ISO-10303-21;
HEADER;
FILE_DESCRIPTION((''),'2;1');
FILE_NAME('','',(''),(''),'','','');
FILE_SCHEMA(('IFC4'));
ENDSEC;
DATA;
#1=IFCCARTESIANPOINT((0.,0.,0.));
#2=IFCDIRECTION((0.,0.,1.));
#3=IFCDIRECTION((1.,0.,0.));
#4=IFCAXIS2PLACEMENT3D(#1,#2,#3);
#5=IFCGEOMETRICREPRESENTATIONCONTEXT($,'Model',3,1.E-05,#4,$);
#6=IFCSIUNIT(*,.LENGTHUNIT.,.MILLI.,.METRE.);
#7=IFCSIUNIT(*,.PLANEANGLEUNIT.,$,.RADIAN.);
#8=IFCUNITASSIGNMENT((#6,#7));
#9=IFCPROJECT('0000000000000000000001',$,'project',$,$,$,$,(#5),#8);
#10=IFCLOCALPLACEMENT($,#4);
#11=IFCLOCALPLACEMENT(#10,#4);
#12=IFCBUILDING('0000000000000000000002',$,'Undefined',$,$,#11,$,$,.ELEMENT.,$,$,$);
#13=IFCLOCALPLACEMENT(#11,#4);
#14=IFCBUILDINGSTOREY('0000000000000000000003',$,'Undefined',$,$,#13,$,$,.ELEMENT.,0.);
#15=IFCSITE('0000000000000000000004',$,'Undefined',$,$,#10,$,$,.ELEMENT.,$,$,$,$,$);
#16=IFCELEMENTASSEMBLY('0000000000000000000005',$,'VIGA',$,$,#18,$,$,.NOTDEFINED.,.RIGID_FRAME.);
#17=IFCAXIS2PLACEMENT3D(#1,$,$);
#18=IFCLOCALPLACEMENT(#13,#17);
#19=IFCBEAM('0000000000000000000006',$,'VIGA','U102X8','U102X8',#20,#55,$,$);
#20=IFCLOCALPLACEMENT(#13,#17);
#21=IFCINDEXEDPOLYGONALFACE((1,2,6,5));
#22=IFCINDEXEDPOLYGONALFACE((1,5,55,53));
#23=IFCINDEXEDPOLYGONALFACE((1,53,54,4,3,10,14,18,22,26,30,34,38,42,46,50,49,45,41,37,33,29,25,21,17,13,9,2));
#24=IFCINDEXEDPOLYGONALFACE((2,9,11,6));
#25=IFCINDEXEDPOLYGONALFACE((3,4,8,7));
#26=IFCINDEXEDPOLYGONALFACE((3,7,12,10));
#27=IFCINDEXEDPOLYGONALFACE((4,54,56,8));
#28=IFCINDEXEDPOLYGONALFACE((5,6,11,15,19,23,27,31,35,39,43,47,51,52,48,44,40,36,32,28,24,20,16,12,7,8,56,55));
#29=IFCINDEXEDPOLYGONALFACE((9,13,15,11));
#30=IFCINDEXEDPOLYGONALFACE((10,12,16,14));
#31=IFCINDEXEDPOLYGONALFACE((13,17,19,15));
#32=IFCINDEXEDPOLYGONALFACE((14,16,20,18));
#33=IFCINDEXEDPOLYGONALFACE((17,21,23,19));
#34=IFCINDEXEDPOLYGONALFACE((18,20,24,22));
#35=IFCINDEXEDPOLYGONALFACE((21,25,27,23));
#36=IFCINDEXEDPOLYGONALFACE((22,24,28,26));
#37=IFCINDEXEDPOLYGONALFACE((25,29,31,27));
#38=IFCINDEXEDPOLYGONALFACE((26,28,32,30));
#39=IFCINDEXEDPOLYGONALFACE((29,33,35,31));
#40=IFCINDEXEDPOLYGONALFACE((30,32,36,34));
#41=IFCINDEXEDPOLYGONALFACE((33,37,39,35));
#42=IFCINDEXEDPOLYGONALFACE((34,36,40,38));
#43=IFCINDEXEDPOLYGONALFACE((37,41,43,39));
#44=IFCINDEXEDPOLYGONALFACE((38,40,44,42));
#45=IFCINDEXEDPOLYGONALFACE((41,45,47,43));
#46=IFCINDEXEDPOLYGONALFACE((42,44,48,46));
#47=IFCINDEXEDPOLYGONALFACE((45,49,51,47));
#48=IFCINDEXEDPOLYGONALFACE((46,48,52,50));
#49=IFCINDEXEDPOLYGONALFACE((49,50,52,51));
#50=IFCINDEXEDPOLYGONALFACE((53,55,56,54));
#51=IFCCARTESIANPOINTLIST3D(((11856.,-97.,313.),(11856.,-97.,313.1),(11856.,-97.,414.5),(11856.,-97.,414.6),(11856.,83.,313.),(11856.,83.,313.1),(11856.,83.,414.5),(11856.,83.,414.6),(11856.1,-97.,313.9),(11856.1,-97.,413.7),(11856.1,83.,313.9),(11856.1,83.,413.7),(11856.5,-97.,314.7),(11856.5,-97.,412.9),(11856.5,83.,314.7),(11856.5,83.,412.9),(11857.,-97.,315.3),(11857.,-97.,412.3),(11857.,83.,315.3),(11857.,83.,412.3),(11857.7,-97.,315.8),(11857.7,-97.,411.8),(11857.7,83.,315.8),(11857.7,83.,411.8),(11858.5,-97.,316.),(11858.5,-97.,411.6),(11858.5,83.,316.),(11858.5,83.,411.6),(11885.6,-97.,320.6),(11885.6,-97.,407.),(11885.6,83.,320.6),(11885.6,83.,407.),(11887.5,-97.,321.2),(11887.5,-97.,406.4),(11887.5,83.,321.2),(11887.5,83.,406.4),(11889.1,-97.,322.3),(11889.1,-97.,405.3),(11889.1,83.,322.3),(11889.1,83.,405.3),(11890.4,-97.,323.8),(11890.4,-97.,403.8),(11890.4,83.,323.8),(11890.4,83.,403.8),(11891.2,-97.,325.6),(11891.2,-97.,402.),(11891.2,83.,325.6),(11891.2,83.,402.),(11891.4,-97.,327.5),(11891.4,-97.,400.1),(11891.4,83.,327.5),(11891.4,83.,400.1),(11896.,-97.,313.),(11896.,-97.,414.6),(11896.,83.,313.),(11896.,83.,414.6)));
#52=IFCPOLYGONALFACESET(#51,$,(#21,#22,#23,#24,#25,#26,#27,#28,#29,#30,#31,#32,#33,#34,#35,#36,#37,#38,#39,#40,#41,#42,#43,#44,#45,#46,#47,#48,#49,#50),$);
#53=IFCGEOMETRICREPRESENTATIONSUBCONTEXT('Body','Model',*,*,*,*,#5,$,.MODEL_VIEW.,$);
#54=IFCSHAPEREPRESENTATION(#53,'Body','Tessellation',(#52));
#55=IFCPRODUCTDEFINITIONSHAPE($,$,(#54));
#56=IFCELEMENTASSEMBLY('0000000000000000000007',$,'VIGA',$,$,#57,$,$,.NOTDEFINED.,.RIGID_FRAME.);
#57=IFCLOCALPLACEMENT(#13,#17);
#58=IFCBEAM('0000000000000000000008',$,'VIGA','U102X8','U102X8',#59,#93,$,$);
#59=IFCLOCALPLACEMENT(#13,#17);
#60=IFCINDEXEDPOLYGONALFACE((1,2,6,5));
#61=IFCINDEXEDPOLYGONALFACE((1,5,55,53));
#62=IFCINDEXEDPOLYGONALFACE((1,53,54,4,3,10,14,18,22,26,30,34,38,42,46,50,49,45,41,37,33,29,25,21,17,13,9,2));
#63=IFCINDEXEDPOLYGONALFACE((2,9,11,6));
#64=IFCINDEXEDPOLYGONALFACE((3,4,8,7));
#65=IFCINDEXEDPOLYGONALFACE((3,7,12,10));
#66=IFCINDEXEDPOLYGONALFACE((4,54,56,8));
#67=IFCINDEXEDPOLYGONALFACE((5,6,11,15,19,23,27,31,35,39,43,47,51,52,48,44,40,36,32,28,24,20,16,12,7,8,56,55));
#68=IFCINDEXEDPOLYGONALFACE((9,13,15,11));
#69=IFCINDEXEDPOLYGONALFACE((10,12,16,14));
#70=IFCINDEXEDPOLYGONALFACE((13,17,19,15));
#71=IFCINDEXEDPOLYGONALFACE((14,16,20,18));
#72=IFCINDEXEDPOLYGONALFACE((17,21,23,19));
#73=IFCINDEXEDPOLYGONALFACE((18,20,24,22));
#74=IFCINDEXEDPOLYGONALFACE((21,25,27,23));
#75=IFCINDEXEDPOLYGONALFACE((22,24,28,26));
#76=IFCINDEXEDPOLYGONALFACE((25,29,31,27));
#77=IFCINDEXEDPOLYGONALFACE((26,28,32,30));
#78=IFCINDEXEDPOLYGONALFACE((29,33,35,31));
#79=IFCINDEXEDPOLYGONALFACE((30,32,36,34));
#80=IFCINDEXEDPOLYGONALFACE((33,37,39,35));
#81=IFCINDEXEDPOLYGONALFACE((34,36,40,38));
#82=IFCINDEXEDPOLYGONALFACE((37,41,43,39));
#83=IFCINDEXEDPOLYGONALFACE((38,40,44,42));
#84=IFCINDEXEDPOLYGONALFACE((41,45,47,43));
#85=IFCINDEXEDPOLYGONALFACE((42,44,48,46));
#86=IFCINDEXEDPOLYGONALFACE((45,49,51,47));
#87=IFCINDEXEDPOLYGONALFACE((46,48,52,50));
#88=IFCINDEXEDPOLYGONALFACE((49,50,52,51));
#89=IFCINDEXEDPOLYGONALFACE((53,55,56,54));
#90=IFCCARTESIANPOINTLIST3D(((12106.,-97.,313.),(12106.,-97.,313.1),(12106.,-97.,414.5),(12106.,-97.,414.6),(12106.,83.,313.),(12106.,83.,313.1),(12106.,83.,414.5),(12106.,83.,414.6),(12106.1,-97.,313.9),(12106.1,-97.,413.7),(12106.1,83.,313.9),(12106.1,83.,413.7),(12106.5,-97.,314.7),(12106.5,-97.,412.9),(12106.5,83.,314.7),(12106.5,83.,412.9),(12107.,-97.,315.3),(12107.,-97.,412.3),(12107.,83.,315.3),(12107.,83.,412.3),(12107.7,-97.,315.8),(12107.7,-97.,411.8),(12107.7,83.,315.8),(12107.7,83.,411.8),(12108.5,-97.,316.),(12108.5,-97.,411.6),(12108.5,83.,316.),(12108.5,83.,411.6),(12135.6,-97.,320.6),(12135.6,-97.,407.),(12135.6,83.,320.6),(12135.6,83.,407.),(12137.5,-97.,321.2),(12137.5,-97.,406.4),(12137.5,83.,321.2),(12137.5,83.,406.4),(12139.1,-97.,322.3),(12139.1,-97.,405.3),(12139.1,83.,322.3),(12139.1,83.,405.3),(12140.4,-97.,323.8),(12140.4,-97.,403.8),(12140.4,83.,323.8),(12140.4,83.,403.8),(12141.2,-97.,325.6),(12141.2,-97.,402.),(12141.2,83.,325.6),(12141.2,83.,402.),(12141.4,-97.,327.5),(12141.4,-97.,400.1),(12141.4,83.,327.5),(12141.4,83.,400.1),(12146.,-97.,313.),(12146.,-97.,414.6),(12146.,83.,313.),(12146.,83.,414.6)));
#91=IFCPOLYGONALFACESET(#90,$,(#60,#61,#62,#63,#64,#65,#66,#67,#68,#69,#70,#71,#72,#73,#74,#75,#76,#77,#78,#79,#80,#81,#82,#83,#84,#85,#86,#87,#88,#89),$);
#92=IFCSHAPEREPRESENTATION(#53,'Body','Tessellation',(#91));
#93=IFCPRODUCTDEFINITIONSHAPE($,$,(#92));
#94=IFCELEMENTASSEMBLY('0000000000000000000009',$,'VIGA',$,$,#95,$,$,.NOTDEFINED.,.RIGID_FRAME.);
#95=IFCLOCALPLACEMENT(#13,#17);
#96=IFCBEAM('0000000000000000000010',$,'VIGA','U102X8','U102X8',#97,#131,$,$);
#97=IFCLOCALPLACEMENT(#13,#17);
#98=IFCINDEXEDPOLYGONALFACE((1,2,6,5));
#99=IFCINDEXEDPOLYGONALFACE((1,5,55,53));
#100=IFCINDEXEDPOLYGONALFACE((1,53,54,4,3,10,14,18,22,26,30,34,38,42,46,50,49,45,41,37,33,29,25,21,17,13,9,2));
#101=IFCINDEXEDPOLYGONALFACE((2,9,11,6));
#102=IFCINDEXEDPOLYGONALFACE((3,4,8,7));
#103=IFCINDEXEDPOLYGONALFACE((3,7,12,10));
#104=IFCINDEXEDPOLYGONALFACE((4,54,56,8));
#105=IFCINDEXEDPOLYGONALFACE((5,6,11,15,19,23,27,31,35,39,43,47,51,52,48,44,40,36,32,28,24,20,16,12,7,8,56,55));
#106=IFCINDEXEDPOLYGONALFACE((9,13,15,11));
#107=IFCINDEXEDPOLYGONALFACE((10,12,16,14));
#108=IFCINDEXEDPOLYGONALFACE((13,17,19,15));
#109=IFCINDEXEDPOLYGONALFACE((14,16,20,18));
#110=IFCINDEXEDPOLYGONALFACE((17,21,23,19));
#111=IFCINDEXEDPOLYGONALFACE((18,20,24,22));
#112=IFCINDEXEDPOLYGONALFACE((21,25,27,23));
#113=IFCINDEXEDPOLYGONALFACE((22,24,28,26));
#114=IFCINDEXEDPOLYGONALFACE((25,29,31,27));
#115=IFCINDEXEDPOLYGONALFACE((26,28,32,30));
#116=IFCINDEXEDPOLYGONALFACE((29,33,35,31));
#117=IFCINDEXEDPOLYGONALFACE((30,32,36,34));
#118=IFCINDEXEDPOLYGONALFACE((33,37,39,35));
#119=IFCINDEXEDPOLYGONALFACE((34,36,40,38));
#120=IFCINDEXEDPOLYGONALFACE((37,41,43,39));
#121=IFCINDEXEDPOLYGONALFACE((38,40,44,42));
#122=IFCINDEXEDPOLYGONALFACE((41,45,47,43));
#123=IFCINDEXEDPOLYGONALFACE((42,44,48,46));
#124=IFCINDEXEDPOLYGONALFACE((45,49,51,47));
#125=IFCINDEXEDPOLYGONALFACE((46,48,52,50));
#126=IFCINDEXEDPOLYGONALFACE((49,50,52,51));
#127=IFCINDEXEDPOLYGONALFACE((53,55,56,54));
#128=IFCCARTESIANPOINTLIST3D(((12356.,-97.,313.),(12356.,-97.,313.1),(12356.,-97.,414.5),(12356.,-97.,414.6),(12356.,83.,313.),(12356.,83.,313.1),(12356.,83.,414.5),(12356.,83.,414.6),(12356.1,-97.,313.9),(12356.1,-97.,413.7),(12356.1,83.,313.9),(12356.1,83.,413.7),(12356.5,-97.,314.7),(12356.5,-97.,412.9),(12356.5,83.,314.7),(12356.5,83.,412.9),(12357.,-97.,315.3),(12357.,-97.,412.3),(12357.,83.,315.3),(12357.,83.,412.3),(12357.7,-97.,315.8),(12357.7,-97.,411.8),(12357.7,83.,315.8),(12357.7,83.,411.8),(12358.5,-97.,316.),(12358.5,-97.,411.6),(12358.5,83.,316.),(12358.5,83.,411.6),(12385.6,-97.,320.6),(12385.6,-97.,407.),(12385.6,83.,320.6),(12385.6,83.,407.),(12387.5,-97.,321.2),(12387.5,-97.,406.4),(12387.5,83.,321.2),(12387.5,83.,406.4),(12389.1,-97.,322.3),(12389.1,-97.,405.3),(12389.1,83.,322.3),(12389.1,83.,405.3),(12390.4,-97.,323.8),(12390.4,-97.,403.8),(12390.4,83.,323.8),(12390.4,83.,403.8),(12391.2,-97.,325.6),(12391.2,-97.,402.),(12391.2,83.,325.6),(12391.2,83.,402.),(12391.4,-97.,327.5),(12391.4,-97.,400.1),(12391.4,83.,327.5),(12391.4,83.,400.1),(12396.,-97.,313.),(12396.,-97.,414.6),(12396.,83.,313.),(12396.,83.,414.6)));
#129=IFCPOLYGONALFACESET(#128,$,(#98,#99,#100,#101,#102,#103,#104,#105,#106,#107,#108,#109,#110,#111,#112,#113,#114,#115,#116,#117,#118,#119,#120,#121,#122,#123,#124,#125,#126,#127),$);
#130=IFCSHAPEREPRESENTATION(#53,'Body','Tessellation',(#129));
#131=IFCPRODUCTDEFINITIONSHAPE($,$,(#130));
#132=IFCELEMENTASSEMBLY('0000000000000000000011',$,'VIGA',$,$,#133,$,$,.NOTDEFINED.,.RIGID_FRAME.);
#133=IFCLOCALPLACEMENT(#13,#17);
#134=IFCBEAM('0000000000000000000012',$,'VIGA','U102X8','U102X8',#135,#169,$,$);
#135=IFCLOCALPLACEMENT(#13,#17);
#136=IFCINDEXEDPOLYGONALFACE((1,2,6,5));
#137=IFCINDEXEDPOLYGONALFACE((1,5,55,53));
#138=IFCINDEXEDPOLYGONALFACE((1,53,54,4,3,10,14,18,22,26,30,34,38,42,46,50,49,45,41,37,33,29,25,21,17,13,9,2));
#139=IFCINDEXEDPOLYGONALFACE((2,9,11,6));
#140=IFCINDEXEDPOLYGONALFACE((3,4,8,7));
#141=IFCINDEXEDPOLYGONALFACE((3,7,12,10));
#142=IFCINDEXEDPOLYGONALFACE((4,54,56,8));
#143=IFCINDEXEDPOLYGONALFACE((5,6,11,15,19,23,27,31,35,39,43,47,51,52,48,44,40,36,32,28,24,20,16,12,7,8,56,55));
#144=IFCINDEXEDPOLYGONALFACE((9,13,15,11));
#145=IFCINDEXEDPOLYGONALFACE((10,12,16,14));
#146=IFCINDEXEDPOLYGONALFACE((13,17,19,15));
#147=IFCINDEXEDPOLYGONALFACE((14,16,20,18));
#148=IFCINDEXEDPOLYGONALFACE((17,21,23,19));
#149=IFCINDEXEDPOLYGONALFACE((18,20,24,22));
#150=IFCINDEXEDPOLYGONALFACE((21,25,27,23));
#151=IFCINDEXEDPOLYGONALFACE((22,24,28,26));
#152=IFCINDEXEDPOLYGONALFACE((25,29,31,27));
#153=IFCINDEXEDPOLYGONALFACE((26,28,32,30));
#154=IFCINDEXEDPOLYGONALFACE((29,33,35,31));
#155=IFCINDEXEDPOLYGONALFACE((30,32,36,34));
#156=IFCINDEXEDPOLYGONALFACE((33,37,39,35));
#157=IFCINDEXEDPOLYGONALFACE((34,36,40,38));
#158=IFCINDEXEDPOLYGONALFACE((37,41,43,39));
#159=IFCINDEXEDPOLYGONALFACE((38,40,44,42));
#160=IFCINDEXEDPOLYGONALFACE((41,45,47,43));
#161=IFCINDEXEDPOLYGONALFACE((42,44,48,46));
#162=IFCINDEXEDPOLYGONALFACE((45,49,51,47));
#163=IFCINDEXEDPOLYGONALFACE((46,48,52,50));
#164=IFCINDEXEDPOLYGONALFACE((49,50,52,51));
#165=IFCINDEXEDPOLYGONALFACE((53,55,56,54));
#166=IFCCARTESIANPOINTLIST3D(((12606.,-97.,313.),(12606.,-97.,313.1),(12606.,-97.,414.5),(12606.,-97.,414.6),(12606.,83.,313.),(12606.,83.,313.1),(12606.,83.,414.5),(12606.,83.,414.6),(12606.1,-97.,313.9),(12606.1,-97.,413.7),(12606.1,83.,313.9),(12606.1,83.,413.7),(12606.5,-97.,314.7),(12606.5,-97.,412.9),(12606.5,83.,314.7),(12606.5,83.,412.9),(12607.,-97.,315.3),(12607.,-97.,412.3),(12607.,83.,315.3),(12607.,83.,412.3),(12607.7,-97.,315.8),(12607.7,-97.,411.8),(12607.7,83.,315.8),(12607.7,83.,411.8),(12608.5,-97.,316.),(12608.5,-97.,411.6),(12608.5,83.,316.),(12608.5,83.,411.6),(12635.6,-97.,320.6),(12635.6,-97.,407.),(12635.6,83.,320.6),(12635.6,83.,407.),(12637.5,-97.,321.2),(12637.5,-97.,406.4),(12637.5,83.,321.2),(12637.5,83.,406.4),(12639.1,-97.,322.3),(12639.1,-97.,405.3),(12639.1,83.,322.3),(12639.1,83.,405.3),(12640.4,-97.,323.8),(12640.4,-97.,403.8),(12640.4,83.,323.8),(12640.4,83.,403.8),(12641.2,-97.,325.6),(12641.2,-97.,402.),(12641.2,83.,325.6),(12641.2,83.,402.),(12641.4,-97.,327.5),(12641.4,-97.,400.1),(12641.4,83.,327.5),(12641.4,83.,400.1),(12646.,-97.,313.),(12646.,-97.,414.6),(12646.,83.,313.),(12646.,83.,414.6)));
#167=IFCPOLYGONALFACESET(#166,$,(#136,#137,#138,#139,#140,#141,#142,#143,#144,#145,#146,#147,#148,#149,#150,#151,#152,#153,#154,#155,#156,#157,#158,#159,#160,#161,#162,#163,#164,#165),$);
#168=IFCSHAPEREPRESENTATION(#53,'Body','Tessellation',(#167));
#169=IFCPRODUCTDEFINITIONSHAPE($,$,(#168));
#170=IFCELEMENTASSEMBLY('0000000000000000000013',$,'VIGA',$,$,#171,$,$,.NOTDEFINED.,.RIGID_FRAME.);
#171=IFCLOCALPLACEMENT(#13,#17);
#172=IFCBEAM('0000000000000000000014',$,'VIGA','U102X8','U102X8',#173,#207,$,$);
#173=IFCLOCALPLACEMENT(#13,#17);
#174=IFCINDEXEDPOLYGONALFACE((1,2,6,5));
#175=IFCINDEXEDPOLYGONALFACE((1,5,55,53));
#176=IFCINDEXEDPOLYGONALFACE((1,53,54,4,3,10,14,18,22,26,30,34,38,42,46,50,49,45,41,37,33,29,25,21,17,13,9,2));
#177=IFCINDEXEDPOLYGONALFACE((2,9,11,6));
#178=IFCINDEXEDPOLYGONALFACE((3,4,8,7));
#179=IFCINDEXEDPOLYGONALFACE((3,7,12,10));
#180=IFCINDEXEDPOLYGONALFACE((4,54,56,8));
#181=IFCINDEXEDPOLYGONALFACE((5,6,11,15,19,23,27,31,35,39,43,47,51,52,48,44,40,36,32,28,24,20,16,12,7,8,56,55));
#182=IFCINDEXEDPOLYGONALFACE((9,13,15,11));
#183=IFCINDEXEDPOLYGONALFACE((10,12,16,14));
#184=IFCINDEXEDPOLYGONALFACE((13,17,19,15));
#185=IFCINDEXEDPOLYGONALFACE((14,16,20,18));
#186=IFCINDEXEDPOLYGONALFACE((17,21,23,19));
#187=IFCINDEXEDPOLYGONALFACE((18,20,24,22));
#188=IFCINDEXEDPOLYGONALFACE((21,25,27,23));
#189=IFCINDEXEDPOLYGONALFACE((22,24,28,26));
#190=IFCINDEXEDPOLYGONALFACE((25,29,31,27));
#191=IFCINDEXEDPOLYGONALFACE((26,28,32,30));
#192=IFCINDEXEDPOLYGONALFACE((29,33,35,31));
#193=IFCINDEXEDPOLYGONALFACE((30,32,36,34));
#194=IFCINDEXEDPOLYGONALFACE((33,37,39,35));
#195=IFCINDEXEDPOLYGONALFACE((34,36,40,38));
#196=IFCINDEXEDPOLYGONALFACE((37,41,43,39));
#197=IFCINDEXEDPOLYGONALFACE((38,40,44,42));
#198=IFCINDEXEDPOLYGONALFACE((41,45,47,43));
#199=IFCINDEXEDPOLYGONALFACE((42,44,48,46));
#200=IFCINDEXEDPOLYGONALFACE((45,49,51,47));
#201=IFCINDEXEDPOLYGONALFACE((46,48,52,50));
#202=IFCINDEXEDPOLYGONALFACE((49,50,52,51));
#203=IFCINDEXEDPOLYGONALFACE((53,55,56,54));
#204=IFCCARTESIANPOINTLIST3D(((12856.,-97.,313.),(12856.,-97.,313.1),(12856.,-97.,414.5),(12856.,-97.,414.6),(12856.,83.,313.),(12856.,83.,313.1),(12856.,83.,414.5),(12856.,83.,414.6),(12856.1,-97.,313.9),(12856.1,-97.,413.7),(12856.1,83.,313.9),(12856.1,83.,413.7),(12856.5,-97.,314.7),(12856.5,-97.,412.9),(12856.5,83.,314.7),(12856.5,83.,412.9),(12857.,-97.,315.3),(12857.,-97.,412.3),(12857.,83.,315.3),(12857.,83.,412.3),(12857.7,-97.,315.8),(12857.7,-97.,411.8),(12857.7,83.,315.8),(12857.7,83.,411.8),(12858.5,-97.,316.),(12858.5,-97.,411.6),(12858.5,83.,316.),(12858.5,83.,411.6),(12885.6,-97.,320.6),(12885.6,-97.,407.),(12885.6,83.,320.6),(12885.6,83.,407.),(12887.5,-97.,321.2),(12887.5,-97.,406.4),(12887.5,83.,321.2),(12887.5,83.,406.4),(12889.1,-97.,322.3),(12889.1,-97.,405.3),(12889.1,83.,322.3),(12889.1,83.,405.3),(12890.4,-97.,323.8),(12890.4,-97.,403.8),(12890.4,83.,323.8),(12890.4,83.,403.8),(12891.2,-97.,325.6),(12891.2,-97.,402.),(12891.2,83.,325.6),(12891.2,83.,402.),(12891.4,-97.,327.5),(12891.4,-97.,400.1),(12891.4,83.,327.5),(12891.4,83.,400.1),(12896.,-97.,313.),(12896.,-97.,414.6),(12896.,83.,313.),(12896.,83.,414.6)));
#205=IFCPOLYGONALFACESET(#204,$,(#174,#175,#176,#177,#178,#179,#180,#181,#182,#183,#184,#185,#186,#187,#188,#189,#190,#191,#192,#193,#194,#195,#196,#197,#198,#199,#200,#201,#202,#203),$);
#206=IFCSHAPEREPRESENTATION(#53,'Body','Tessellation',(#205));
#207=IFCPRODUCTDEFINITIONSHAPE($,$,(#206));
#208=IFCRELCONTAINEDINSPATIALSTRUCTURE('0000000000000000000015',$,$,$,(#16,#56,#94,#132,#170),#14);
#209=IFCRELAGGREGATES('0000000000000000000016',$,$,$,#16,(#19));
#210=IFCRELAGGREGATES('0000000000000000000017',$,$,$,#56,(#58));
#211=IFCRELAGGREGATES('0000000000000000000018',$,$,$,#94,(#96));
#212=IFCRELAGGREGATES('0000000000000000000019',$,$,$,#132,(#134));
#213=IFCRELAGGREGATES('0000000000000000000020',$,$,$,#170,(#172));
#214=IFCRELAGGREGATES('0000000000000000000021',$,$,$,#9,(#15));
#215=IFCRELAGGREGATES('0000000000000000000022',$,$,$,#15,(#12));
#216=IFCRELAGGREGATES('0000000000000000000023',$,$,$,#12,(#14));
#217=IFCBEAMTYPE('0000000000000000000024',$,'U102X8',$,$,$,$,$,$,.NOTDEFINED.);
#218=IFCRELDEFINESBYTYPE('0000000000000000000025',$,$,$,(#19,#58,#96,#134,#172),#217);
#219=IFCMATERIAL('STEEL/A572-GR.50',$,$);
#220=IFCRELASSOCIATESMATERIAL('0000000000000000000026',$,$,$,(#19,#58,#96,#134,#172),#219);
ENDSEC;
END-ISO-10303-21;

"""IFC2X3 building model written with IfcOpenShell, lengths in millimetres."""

from ifc_helpers import new_model, si_unit, frame, origin_with_axes, origin_2d_with_axis, place, context, subcontext, project, spatial, u_section, extrude, material, type_object, element, aggregate, save


model = new_model("IFC2X3")

# Units and contexts
model_context = context("Model", 3, precision=1e-05, world=origin_with_axes())
body_context = subcontext(model_context, "Body", "Model", "MODEL_VIEW")
ifc_project = project(units=[si_unit("LENGTHUNIT", "METRE", prefix="MILLI"), si_unit("PLANEANGLEUNIT", "RADIAN")], contexts=[model_context])

# Site, building, storey
site_placement = place(None, origin_with_axes())
site = spatial("IfcSite", under=ifc_project, at=site_placement, Name="Undefined", CompositionType="ELEMENT")
building_placement = place(site_placement, origin_with_axes())
building = spatial("IfcBuilding", under=site, at=building_placement, Name="Undefined", CompositionType="ELEMENT")
storey_placement = place(building_placement, origin_with_axes())
storey = spatial("IfcBuildingStorey", under=building, at=storey_placement, Name="Undefined", CompositionType="ELEMENT", Elevation=0.0)

# Element assemblies, beams
ifc_material = material(Name="STEEL/A572-GR.50")
beam_type = type_object("IfcBeamType", Name="U102X8", PredefinedType="NOTDEFINED")
assembly_1_placement = place(storey_placement, origin_with_axes())
assembly_1 = element("IfcElementAssembly", 1, at=assembly_1_placement, inside=storey, Name="VIGA", AssemblyPlace="NOTDEFINED", PredefinedType="RIGID_FRAME")
beam_1_placement = place(assembly_1_placement, frame((11876.0, 83.0, 363.8), z_axis=(0.0, 0.0, 1.0), x_axis=(0.0, -1.0, 0.0)))
beam_1 = element("IfcBeam", 2, at=beam_1_placement, type_object=beam_type, material=ifc_material, Name="VIGA", Description="U102X8", ObjectType="U102X8", context=body_context, shape_type="SweptSolid", body=[
    extrude(u_section(Depth=101.6, FlangeWidth=40.0, WebThickness=4.6, FlangeThickness=6.0, FilletRadius=7.0, EdgeRadius=3.0, FlangeSlope=0.16839, at=origin_2d_with_axis()), frame((180.0, 0.0, 0.0), z_axis=(-1.0, 0.0, 0.0), x_axis=(0.0, -1.0, 0.0)), (0.0, 0.0, 1.0), 180.0),
])
aggregate(assembly_1, [beam_1])
assembly_2_placement = place(storey_placement, origin_with_axes())
assembly_2 = element("IfcElementAssembly", 3, at=assembly_2_placement, inside=storey, Name="VIGA", AssemblyPlace="NOTDEFINED", PredefinedType="RIGID_FRAME")
beam_2_placement = place(assembly_2_placement, frame((12126.0, 83.0, 363.8), z_axis=(0.0, 0.0, 1.0), x_axis=(0.0, -1.0, 0.0)))
beam_2 = element("IfcBeam", 4, at=beam_2_placement, type_object=beam_type, material=ifc_material, Name="VIGA", Description="U102X8", ObjectType="U102X8", context=body_context, shape_type="SweptSolid", body=[
    extrude(u_section(Depth=101.6, FlangeWidth=40.0, WebThickness=4.6, FlangeThickness=6.0, FilletRadius=7.0, EdgeRadius=3.0, FlangeSlope=0.16839, at=origin_2d_with_axis()), frame((180.0, 0.0, 0.0), z_axis=(-1.0, 0.0, 0.0), x_axis=(0.0, -1.0, 0.0)), (0.0, 0.0, 1.0), 180.0),
])
aggregate(assembly_2, [beam_2])
assembly_3_placement = place(storey_placement, origin_with_axes())
assembly_3 = element("IfcElementAssembly", 5, at=assembly_3_placement, inside=storey, Name="VIGA", AssemblyPlace="NOTDEFINED", PredefinedType="RIGID_FRAME")
beam_3_placement = place(assembly_3_placement, frame((12376.0, 83.0, 363.8), z_axis=(0.0, 0.0, 1.0), x_axis=(0.0, -1.0, 0.0)))
beam_3 = element("IfcBeam", 6, at=beam_3_placement, type_object=beam_type, material=ifc_material, Name="VIGA", Description="U102X8", ObjectType="U102X8", context=body_context, shape_type="SweptSolid", body=[
    extrude(u_section(Depth=101.6, FlangeWidth=40.0, WebThickness=4.6, FlangeThickness=6.0, FilletRadius=7.0, EdgeRadius=3.0, FlangeSlope=0.16839, at=origin_2d_with_axis()), frame((180.0, 0.0, 0.0), z_axis=(-1.0, 0.0, 0.0), x_axis=(0.0, -1.0, 0.0)), (0.0, 0.0, 1.0), 180.0),
])
aggregate(assembly_3, [beam_3])
assembly_4_placement = place(storey_placement, origin_with_axes())
assembly_4 = element("IfcElementAssembly", 7, at=assembly_4_placement, inside=storey, Name="VIGA", AssemblyPlace="NOTDEFINED", PredefinedType="RIGID_FRAME")
beam_4_placement = place(assembly_4_placement, frame((12626.0, 83.0, 363.8), z_axis=(0.0, 0.0, 1.0), x_axis=(0.0, -1.0, 0.0)))
beam_4 = element("IfcBeam", 8, at=beam_4_placement, type_object=beam_type, material=ifc_material, Name="VIGA", Description="U102X8", ObjectType="U102X8", context=body_context, shape_type="SweptSolid", body=[
    extrude(u_section(Depth=101.6, FlangeWidth=40.0, WebThickness=4.6, FlangeThickness=6.0, FilletRadius=7.0, EdgeRadius=3.0, FlangeSlope=0.16839, at=origin_2d_with_axis()), frame((180.0, 0.0, 0.0), z_axis=(-1.0, 0.0, 0.0), x_axis=(0.0, -1.0, 0.0)), (0.0, 0.0, 1.0), 180.0),
])
aggregate(assembly_4, [beam_4])
assembly_5_placement = place(storey_placement, origin_with_axes())
assembly_5 = element("IfcElementAssembly", 9, at=assembly_5_placement, inside=storey, Name="VIGA", AssemblyPlace="NOTDEFINED", PredefinedType="RIGID_FRAME")
beam_5_placement = place(assembly_5_placement, frame((12876.0, 83.0, 363.8), z_axis=(0.0, 0.0, 1.0), x_axis=(0.0, -1.0, 0.0)))
beam_5 = element("IfcBeam", 10, at=beam_5_placement, type_object=beam_type, material=ifc_material, Name="VIGA", Description="U102X8", ObjectType="U102X8", context=body_context, shape_type="SweptSolid", body=[
    extrude(u_section(Depth=101.6, FlangeWidth=40.0, WebThickness=4.6, FlangeThickness=6.0, FilletRadius=7.0, EdgeRadius=3.0, FlangeSlope=0.16839, at=origin_2d_with_axis()), frame((180.0, 0.0, 0.0), z_axis=(-1.0, 0.0, 0.0), x_axis=(0.0, -1.0, 0.0)), (0.0, 0.0, 1.0), 180.0),
])
aggregate(assembly_5, [beam_5])

save(model, "model.ifc")
